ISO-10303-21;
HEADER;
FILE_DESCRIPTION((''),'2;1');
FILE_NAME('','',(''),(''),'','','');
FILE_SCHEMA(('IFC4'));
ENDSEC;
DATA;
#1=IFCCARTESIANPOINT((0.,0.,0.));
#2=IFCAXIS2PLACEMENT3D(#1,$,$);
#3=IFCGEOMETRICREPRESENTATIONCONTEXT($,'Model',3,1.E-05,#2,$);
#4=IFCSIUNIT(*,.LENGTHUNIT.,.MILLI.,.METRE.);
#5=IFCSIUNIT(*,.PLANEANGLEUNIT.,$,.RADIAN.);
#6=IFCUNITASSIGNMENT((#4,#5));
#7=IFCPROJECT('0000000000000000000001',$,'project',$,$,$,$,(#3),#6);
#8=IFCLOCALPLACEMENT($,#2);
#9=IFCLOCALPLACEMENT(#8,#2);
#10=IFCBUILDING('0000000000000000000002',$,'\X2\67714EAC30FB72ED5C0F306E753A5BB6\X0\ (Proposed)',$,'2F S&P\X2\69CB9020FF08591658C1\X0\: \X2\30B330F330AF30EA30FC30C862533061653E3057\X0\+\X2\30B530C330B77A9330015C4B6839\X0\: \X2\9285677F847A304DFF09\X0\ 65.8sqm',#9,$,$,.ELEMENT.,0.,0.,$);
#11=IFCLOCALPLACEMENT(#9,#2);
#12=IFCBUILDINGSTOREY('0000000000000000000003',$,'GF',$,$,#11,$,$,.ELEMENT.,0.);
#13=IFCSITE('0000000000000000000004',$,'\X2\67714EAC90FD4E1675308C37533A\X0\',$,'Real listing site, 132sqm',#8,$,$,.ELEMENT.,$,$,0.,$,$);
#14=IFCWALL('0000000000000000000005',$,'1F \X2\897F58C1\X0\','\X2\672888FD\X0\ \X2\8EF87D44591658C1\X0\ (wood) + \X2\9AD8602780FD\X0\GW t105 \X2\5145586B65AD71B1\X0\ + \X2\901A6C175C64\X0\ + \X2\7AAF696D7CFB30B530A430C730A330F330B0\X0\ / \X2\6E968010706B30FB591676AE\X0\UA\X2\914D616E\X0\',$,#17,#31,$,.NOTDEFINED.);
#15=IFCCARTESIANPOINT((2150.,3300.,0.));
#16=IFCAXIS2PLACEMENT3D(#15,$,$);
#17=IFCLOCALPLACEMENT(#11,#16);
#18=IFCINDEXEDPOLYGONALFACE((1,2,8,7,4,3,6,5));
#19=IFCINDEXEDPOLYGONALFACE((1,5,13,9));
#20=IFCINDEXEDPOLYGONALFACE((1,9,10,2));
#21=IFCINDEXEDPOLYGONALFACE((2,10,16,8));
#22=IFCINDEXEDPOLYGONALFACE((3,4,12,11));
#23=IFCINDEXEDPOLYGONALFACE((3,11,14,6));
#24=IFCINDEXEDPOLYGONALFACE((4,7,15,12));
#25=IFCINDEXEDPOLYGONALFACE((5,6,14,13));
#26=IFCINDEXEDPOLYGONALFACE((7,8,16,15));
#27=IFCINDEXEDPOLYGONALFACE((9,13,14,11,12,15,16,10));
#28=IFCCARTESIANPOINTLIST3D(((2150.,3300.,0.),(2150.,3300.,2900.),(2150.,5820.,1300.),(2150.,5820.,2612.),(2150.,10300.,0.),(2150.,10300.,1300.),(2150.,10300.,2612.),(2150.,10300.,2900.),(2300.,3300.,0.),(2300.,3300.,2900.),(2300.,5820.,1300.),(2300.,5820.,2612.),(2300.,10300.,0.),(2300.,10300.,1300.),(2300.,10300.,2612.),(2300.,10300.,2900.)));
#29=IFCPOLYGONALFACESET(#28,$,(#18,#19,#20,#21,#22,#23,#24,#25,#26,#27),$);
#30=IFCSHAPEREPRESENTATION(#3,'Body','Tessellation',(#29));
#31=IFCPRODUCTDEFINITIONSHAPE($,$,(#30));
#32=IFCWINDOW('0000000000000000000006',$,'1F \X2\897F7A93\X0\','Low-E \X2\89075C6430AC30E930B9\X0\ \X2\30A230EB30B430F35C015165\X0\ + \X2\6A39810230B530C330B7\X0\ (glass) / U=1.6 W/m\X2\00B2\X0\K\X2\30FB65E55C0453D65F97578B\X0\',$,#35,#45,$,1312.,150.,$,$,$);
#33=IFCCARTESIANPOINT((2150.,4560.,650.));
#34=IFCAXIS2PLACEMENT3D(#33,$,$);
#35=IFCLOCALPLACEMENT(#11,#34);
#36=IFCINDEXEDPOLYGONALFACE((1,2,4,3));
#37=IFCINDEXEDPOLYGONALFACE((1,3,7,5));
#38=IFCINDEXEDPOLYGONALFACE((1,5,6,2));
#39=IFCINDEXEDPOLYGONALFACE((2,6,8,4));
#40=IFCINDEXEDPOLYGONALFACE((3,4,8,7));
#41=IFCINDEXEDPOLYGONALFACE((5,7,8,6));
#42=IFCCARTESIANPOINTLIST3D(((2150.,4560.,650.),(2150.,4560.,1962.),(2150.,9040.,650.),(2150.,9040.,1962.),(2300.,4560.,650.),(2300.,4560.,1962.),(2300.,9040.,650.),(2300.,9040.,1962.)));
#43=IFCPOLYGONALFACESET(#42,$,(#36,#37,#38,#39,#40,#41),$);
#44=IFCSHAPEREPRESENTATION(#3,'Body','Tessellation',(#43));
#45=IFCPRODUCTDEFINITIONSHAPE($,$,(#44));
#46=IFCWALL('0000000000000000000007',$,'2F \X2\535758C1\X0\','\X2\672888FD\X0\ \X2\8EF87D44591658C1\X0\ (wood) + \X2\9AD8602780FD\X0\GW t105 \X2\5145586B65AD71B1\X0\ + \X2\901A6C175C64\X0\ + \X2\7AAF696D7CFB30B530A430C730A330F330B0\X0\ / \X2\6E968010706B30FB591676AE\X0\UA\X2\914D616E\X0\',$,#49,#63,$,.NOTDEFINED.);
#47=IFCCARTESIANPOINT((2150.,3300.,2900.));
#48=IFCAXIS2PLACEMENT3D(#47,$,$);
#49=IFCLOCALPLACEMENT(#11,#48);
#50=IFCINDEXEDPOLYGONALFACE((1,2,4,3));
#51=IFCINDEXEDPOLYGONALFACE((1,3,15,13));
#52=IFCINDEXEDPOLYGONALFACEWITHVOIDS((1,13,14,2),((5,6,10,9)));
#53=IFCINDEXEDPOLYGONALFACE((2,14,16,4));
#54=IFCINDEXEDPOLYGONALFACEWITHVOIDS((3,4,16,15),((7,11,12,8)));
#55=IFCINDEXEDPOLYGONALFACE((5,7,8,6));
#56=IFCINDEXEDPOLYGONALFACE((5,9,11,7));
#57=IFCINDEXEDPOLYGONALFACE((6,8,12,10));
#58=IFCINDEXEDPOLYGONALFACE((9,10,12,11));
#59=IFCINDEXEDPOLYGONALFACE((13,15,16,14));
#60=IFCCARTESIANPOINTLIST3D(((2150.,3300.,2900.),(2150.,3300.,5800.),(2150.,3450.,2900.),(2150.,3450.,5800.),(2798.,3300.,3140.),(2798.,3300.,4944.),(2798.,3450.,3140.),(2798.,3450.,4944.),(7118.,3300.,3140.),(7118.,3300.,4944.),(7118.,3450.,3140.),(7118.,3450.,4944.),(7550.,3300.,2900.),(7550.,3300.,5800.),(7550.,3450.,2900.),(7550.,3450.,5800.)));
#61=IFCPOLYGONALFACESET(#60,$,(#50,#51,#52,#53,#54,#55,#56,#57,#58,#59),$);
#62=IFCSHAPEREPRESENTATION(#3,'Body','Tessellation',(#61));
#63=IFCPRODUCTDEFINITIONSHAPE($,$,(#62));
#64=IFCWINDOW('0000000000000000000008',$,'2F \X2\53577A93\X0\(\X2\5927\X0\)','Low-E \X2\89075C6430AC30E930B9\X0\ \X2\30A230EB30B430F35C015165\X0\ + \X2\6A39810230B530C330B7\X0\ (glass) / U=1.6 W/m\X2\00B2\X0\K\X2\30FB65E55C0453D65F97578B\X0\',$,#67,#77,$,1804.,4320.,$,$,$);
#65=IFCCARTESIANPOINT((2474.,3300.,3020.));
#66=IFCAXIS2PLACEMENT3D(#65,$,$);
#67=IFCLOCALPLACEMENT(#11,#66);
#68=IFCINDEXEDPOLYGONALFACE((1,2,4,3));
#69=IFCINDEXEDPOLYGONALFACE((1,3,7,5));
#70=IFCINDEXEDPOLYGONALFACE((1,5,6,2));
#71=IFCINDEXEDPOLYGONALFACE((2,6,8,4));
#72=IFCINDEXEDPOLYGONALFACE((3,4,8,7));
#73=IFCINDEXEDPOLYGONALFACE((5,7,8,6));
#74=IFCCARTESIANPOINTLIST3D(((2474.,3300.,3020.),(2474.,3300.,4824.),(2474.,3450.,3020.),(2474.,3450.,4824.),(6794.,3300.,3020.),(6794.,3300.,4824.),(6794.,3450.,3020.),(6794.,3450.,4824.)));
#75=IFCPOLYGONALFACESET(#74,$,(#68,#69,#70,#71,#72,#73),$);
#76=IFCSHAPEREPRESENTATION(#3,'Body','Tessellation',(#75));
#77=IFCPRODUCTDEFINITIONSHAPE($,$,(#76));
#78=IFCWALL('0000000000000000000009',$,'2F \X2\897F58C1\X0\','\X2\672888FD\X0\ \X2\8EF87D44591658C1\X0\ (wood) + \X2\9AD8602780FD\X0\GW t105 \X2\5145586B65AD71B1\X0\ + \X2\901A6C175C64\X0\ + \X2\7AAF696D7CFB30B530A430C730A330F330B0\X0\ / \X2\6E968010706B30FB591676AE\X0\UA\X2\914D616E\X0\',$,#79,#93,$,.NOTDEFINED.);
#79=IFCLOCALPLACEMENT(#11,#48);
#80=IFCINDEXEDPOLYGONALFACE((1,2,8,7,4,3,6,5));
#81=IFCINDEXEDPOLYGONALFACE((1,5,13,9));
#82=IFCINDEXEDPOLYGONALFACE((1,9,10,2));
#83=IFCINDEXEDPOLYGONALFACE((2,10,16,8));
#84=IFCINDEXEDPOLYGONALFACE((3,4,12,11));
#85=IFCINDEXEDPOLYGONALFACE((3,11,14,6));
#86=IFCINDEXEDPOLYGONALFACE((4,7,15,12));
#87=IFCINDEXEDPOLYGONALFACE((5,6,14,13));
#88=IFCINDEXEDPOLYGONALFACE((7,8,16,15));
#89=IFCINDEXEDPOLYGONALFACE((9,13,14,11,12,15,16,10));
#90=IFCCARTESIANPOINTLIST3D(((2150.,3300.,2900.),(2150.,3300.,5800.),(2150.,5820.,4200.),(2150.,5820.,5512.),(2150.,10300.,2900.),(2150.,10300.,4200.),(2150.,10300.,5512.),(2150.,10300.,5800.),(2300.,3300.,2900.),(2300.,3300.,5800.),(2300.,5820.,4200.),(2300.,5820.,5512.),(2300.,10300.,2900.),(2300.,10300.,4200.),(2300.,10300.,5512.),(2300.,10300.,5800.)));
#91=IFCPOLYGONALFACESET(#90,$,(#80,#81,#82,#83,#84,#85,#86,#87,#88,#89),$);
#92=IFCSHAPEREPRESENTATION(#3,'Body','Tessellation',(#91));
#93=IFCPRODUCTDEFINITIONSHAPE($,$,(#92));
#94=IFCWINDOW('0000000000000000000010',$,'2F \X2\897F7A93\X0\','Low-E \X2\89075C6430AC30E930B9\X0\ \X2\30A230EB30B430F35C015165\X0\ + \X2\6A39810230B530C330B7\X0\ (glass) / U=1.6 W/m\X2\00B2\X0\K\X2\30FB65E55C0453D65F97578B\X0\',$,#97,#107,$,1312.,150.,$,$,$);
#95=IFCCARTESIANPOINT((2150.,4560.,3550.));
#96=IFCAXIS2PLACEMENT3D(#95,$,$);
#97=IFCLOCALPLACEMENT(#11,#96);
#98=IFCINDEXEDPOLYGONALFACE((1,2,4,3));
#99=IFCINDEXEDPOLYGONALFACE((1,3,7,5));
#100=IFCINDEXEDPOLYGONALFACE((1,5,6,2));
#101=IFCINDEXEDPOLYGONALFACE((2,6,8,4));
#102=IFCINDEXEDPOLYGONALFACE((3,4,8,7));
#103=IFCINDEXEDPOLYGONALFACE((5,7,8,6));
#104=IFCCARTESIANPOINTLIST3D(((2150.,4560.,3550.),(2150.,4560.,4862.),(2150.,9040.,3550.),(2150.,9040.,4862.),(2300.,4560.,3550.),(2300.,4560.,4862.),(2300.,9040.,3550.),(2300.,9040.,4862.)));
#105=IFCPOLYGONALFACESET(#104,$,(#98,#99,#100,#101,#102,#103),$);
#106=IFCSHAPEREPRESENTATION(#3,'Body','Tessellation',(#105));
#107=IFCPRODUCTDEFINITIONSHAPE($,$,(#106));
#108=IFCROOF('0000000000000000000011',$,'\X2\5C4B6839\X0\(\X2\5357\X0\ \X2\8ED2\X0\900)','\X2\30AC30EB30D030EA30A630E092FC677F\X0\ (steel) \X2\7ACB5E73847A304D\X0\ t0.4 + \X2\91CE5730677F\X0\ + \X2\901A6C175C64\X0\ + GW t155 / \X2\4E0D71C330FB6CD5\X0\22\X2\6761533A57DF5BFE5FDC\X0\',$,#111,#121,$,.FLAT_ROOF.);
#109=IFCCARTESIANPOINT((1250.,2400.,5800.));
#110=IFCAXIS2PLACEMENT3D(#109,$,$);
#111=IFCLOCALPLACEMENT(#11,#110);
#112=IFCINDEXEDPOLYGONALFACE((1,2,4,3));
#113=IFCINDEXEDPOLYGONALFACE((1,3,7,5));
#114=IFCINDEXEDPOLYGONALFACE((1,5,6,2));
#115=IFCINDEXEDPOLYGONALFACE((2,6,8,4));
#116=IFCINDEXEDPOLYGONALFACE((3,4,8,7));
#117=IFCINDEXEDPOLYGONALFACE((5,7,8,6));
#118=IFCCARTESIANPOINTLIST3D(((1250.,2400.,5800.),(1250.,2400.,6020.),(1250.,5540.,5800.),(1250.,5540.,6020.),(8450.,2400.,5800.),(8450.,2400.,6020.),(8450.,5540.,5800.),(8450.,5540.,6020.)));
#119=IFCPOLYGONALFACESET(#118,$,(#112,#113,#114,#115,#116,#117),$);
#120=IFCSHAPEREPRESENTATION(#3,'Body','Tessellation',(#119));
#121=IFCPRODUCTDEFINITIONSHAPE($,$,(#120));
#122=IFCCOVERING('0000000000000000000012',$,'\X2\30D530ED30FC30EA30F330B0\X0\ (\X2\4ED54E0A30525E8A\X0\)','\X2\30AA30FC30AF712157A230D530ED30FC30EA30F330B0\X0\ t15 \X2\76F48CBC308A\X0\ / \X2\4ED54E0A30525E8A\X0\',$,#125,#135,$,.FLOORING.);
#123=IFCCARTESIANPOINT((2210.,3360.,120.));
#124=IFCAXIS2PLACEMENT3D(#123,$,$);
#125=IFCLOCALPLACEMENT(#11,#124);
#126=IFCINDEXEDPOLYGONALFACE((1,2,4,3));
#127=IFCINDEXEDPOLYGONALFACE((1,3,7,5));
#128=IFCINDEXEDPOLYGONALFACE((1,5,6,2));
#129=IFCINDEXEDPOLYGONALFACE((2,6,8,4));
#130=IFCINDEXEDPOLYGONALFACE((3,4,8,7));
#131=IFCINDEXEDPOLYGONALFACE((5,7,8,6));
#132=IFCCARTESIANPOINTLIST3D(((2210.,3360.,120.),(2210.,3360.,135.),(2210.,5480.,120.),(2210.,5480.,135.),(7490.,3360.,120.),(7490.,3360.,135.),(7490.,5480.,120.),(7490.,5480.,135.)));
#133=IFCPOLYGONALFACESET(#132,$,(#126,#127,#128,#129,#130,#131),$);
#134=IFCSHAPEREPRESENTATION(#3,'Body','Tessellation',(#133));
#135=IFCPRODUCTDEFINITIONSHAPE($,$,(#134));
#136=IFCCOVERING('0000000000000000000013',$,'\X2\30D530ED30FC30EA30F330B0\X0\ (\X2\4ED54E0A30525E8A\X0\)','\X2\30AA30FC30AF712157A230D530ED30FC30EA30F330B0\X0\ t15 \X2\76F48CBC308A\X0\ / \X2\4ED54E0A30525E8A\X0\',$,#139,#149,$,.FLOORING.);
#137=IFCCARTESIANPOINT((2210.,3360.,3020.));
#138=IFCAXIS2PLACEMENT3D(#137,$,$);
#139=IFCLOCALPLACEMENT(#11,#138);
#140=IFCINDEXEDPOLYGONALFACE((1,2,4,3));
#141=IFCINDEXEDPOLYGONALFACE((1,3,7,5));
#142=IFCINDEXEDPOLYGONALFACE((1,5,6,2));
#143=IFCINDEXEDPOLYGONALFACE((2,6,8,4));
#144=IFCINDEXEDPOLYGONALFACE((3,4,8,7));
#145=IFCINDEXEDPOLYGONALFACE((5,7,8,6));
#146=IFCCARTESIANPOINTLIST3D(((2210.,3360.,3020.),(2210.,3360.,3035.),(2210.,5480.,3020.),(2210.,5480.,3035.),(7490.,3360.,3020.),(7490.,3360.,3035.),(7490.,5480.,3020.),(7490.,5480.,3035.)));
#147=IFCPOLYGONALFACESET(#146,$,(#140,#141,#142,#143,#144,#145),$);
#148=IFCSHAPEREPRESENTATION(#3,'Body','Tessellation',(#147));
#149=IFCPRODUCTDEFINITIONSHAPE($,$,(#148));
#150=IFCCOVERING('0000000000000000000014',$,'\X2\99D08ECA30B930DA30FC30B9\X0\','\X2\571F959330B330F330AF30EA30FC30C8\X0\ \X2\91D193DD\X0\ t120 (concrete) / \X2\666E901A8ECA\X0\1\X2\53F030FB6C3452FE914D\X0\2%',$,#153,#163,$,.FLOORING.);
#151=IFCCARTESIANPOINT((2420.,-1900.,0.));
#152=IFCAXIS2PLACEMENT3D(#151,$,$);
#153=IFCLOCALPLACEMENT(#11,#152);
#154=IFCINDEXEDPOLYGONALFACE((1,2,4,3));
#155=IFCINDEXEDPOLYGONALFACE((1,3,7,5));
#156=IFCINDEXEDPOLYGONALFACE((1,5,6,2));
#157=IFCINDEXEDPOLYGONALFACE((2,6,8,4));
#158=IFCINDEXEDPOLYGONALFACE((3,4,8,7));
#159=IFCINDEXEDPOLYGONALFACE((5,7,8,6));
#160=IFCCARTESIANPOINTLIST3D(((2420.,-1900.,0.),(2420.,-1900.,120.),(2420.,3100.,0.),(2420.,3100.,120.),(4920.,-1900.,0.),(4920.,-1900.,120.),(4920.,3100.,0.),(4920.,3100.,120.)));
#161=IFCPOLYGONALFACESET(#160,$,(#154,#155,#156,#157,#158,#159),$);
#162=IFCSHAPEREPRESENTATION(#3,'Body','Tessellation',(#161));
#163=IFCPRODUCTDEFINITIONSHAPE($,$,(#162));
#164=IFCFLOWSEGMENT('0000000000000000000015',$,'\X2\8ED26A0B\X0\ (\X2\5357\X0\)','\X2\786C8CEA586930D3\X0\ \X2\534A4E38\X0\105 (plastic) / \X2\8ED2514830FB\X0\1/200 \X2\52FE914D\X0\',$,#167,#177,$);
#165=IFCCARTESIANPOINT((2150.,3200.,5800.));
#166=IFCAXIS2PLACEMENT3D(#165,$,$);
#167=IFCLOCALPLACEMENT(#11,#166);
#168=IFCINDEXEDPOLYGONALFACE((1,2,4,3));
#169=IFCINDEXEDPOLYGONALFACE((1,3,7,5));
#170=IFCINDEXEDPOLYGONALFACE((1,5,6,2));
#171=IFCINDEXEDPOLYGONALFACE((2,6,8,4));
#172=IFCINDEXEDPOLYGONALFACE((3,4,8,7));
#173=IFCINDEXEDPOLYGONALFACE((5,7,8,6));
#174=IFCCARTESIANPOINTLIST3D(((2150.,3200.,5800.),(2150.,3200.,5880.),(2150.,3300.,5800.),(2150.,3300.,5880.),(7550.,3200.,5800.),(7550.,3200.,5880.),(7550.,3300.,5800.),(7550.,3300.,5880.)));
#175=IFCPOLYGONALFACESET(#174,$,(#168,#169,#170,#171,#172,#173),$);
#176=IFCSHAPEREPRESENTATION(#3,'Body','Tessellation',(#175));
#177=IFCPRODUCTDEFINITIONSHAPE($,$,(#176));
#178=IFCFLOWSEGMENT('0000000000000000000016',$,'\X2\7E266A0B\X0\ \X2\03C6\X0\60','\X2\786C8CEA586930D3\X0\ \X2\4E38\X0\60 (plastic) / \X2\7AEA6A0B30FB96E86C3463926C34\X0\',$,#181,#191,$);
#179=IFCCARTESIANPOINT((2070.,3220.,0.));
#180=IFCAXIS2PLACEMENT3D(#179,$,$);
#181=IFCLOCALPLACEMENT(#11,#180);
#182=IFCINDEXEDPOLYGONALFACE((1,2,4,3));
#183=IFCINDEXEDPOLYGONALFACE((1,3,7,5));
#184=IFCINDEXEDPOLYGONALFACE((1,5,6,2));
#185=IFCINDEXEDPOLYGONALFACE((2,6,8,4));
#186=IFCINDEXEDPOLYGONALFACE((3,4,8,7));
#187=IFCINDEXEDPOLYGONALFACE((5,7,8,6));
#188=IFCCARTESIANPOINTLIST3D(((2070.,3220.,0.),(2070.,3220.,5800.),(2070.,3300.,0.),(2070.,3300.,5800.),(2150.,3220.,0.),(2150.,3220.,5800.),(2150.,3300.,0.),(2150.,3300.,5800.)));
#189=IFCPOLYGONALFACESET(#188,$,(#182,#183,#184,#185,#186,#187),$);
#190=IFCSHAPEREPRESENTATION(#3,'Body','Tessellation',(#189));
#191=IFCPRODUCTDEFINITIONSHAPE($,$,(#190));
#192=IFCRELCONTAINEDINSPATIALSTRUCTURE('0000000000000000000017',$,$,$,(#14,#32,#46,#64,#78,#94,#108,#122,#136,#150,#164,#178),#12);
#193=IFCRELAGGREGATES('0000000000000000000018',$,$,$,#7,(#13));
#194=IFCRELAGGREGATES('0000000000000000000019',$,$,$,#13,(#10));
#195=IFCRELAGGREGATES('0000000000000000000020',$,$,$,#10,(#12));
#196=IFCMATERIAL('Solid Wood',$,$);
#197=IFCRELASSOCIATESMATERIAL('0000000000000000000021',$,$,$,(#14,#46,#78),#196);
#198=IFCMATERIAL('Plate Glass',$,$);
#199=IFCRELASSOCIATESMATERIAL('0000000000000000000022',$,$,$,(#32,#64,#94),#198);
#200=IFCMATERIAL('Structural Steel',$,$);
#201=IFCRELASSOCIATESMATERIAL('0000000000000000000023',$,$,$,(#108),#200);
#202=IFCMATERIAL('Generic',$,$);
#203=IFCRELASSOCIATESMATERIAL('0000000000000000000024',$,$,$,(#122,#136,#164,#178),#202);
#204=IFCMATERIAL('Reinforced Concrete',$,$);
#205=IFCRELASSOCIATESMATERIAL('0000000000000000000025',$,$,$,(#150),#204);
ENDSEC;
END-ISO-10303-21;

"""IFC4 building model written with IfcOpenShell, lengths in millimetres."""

from ifc_helpers import new_model, si_unit, frame, frame_2d, origin, place, context, project, spatial, rectangle, extrude, material, element, fill, save


model = new_model("IFC4")

# Units and contexts
model_context = context("Model", 3, precision=1e-05, world=origin())
ifc_project = project(units=[si_unit("LENGTHUNIT", "METRE", prefix="MILLI"), si_unit("PLANEANGLEUNIT", "RADIAN")], contexts=[model_context])

# Site, building, storey
site_placement = place(None, origin())
site = spatial("IfcSite", under=ifc_project, at=site_placement, Name="東京都世田谷区", ObjectType="Real listing site, 132sqm", CompositionType="ELEMENT", RefElevation=0.0)
building_placement = place(site_placement, origin())
building = spatial("IfcBuilding", under=site, at=building_placement, Name="東京・狭小の町家 (Proposed)", ObjectType="2F S&P構造（外壁: コンクリート打ち放し+サッシ窓、屋根: 銅板葺き） 65.8sqm", CompositionType="ELEMENT", ElevationOfRefHeight=0.0, ElevationOfTerrain=0.0)
storey_placement = place(building_placement, origin())
storey = spatial("IfcBuildingStorey", under=building, at=storey_placement, Name="GF", CompositionType="ELEMENT", Elevation=0.0)

# Shared definitions
ifc_material_1 = material(Name="Solid Wood")

# Shared definitions
ifc_material_2 = material(Name="Reinforced Concrete")

# Shared definitions
ifc_material_3 = material(Name="Plate Glass")

# Walls, openings, windows
wall_1_placement = place(storey_placement, frame((2150.0, 3300.0, 0.0)))
wall_1 = element("IfcWall", 1, at=wall_1_placement, inside=storey, material=ifc_material_1, Name="1F 西壁", Description="木製 軸組外壁 (wood) + 高性能GW t105 充填断熱 + 通気層 + 窯業系サイディング / 準耐火・外皮UA配慮", PredefinedType="NOTDEFINED", context=model_context, shape_type="SweptSolid", body=[
    extrude(rectangle(XDim=150.0, YDim=7000.0, at=frame_2d((75.0, 3500.0))), frame((2150.0, 3300.0, 0.0)), (0.0, 0.0, 1.0), 2900.0),
])
opening_1_placement = place(storey_placement, frame((2150.0, 4560.0, 650.0)))
opening_1 = element("IfcOpeningElement", 2, at=opening_1_placement, cuts=wall_1, PredefinedType="NOTDEFINED", context=model_context, shape_type="SweptSolid", body=[
    extrude(rectangle(XDim=150.0, YDim=4480.0, at=frame_2d((75.0, 2240.0))), frame((2150.0, 4560.0, 650.0)), (0.0, 0.0, 1.0), 1312.0),
])
window_1_placement = place(storey_placement, frame((2150.0, 4560.0, 650.0)))
window_1 = element("IfcWindow", 3, at=window_1_placement, inside=storey, material=ifc_material_3, Name="1F 西窓", Description="Low-E 複層ガラス アルゴン封入 + 樹脂サッシ (glass) / U=1.6 W/m²K・日射取得型", OverallHeight=1312.0, OverallWidth=150.0, context=model_context, shape_type="SweptSolid", body=[
    extrude(rectangle(XDim=150.0, YDim=4480.0, at=frame_2d((75.0, 2240.0))), frame((2150.0, 4560.0, 650.0)), (0.0, 0.0, 1.0), 1312.0),
])
fill(opening_1, window_1)
wall_2_placement = place(storey_placement, frame((2150.0, 3300.0, 2900.0)))
wall_2 = element("IfcWall", 4, at=wall_2_placement, inside=storey, material=ifc_material_1, Name="2F 南壁", Description="木製 軸組外壁 (wood) + 高性能GW t105 充填断熱 + 通気層 + 窯業系サイディング / 準耐火・外皮UA配慮", PredefinedType="NOTDEFINED", context=model_context, shape_type="SweptSolid", body=[
    extrude(rectangle(XDim=5400.0, YDim=150.0, at=frame_2d((2700.0, 75.0))), frame((2150.0, 3300.0, 2900.0)), (0.0, 0.0, 1.0), 2900.0),
])
opening_2_placement = place(storey_placement, frame((2474.0, 3300.0, 3020.0)))
opening_2 = element("IfcOpeningElement", 5, at=opening_2_placement, cuts=wall_2, PredefinedType="NOTDEFINED", context=model_context, shape_type="SweptSolid", body=[
    extrude(rectangle(XDim=4320.0, YDim=150.0, at=frame_2d((2160.0, 75.0))), frame((2474.0, 3300.0, 3020.0)), (0.0, 0.0, 1.0), 1804.0),
])
window_2_placement = place(storey_placement, frame((2474.0, 3300.0, 3020.0)))
window_2 = element("IfcWindow", 6, at=window_2_placement, inside=storey, material=ifc_material_3, Name="2F 南窓(大)", Description="Low-E 複層ガラス アルゴン封入 + 樹脂サッシ (glass) / U=1.6 W/m²K・日射取得型", OverallHeight=1804.0, OverallWidth=4320.0, context=model_context, shape_type="SweptSolid", body=[
    extrude(rectangle(XDim=4320.0, YDim=150.0, at=frame_2d((2160.0, 75.0))), frame((2474.0, 3300.0, 3020.0)), (0.0, 0.0, 1.0), 1804.0),
])
fill(opening_2, window_2)
wall_3_placement = place(storey_placement, frame((2150.0, 3300.0, 2900.0)))
wall_3 = element("IfcWall", 7, at=wall_3_placement, inside=storey, material=ifc_material_1, Name="2F 西壁", Description="木製 軸組外壁 (wood) + 高性能GW t105 充填断熱 + 通気層 + 窯業系サイディング / 準耐火・外皮UA配慮", PredefinedType="NOTDEFINED", context=model_context, shape_type="SweptSolid", body=[
    extrude(rectangle(XDim=150.0, YDim=7000.0, at=frame_2d((75.0, 3500.0))), frame((2150.0, 3300.0, 2900.0)), (0.0, 0.0, 1.0), 2900.0),
])
opening_3_placement = place(storey_placement, frame((2150.0, 4560.0, 3550.0)))
opening_3 = element("IfcOpeningElement", 8, at=opening_3_placement, cuts=wall_3, PredefinedType="NOTDEFINED", context=model_context, shape_type="SweptSolid", body=[
    extrude(rectangle(XDim=150.0, YDim=4480.0, at=frame_2d((75.0, 2240.0))), frame((2150.0, 4560.0, 3550.0)), (0.0, 0.0, 1.0), 1312.0),
])
window_3_placement = place(storey_placement, frame((2150.0, 4560.0, 3550.0)))
window_3 = element("IfcWindow", 9, at=window_3_placement, inside=storey, material=ifc_material_3, Name="2F 西窓", Description="Low-E 複層ガラス アルゴン封入 + 樹脂サッシ (glass) / U=1.6 W/m²K・日射取得型", OverallHeight=1312.0, OverallWidth=150.0, context=model_context, shape_type="SweptSolid", body=[
    extrude(rectangle(XDim=150.0, YDim=4480.0, at=frame_2d((75.0, 2240.0))), frame((2150.0, 4560.0, 3550.0)), (0.0, 0.0, 1.0), 1312.0),
])
fill(opening_3, window_3)

# Roof
ifc_material_4 = material(Name="Structural Steel")
for number, where, name in (
    (10, (1250.0, 2400.0, 5800.0), "屋根(南 軒900)"),
):
    element("IfcRoof", number, at=place(storey_placement, frame(where)), inside=storey, material=ifc_material_4, Name=name, Description="ガルバリウム鋼板 (steel) 立平葺き t0.4 + 野地板 + 通気層 + GW t155 / 不燃・法22条区域対応", PredefinedType="FLAT_ROOF", context=model_context, shape_type="SweptSolid", body=[
        extrude(rectangle(XDim=7200.0, YDim=3140.0, at=frame_2d((3600.0, 1570.0))), frame((1250.0, 2400.0, 5800.0)), (0.0, 0.0, 1.0), 220.0),
    ])

# Coverings
ifc_material_5 = material(Name="Generic")
covering_1_placement = place(storey_placement, frame((2210.0, 3360.0, 120.0)))
element("IfcCovering", 11, at=covering_1_placement, inside=storey, material=ifc_material_5, Name="フローリング (仕上げ床)", Description="オーク無垢フローリング t15 直貼り / 仕上げ床", PredefinedType="FLOORING", context=model_context, shape_type="SweptSolid", body=[
    extrude(rectangle(XDim=5280.0, YDim=2120.0, at=frame_2d((2640.0, 1060.0))), frame((2210.0, 3360.0, 120.0)), (0.0, 0.0, 1.0), 15.0),
])
covering_2_placement = place(storey_placement, frame((2210.0, 3360.0, 3020.0)))
element("IfcCovering", 12, at=covering_2_placement, inside=storey, material=ifc_material_5, Name="フローリング (仕上げ床)", Description="オーク無垢フローリング t15 直貼り / 仕上げ床", PredefinedType="FLOORING", context=model_context, shape_type="SweptSolid", body=[
    extrude(rectangle(XDim=5280.0, YDim=2120.0, at=frame_2d((2640.0, 1060.0))), frame((2210.0, 3360.0, 3020.0)), (0.0, 0.0, 1.0), 15.0),
])
covering_3_placement = place(storey_placement, frame((2420.0, -1900.0, 0.0)))
element("IfcCovering", 13, at=covering_3_placement, inside=storey, material=ifc_material_2, Name="駐車スペース", Description="土間コンクリート 金鏝 t120 (concrete) / 普通車1台・水勾配2%", PredefinedType="FLOORING", context=model_context, shape_type="SweptSolid", body=[
    extrude(rectangle(XDim=2500.0, YDim=5000.0, at=frame_2d((1250.0, 2500.0))), frame((2420.0, -1900.0, 0.0)), (0.0, 0.0, 1.0), 120.0),
])

# Flow segments
flow_segment_1_placement = place(storey_placement, frame((2150.0, 3200.0, 5800.0)))
element("IfcFlowSegment", 14, at=flow_segment_1_placement, inside=storey, material=ifc_material_5, Name="軒樋 (南)", Description="硬質塩ビ 半丸105 (plastic) / 軒先・1/200 勾配", context=model_context, shape_type="SweptSolid", body=[
    extrude(rectangle(XDim=5400.0, YDim=100.0, at=frame_2d((2700.0, 50.0))), frame((2150.0, 3200.0, 5800.0)), (0.0, 0.0, 1.0), 80.0),
])
flow_segment_2_placement = place(storey_placement, frame((2070.0, 3220.0, 0.0)))
element("IfcFlowSegment", 15, at=flow_segment_2_placement, inside=storey, material=ifc_material_5, Name="縦樋 φ60", Description="硬質塩ビ 丸60 (plastic) / 竪樋・雨水排水", context=model_context, shape_type="SweptSolid", body=[
    extrude(rectangle(XDim=80.0, YDim=80.0, at=frame_2d((40.0, 40.0))), frame((2070.0, 3220.0, 0.0)), (0.0, 0.0, 1.0), 5800.0),
])

save(model, "model.ifc")
